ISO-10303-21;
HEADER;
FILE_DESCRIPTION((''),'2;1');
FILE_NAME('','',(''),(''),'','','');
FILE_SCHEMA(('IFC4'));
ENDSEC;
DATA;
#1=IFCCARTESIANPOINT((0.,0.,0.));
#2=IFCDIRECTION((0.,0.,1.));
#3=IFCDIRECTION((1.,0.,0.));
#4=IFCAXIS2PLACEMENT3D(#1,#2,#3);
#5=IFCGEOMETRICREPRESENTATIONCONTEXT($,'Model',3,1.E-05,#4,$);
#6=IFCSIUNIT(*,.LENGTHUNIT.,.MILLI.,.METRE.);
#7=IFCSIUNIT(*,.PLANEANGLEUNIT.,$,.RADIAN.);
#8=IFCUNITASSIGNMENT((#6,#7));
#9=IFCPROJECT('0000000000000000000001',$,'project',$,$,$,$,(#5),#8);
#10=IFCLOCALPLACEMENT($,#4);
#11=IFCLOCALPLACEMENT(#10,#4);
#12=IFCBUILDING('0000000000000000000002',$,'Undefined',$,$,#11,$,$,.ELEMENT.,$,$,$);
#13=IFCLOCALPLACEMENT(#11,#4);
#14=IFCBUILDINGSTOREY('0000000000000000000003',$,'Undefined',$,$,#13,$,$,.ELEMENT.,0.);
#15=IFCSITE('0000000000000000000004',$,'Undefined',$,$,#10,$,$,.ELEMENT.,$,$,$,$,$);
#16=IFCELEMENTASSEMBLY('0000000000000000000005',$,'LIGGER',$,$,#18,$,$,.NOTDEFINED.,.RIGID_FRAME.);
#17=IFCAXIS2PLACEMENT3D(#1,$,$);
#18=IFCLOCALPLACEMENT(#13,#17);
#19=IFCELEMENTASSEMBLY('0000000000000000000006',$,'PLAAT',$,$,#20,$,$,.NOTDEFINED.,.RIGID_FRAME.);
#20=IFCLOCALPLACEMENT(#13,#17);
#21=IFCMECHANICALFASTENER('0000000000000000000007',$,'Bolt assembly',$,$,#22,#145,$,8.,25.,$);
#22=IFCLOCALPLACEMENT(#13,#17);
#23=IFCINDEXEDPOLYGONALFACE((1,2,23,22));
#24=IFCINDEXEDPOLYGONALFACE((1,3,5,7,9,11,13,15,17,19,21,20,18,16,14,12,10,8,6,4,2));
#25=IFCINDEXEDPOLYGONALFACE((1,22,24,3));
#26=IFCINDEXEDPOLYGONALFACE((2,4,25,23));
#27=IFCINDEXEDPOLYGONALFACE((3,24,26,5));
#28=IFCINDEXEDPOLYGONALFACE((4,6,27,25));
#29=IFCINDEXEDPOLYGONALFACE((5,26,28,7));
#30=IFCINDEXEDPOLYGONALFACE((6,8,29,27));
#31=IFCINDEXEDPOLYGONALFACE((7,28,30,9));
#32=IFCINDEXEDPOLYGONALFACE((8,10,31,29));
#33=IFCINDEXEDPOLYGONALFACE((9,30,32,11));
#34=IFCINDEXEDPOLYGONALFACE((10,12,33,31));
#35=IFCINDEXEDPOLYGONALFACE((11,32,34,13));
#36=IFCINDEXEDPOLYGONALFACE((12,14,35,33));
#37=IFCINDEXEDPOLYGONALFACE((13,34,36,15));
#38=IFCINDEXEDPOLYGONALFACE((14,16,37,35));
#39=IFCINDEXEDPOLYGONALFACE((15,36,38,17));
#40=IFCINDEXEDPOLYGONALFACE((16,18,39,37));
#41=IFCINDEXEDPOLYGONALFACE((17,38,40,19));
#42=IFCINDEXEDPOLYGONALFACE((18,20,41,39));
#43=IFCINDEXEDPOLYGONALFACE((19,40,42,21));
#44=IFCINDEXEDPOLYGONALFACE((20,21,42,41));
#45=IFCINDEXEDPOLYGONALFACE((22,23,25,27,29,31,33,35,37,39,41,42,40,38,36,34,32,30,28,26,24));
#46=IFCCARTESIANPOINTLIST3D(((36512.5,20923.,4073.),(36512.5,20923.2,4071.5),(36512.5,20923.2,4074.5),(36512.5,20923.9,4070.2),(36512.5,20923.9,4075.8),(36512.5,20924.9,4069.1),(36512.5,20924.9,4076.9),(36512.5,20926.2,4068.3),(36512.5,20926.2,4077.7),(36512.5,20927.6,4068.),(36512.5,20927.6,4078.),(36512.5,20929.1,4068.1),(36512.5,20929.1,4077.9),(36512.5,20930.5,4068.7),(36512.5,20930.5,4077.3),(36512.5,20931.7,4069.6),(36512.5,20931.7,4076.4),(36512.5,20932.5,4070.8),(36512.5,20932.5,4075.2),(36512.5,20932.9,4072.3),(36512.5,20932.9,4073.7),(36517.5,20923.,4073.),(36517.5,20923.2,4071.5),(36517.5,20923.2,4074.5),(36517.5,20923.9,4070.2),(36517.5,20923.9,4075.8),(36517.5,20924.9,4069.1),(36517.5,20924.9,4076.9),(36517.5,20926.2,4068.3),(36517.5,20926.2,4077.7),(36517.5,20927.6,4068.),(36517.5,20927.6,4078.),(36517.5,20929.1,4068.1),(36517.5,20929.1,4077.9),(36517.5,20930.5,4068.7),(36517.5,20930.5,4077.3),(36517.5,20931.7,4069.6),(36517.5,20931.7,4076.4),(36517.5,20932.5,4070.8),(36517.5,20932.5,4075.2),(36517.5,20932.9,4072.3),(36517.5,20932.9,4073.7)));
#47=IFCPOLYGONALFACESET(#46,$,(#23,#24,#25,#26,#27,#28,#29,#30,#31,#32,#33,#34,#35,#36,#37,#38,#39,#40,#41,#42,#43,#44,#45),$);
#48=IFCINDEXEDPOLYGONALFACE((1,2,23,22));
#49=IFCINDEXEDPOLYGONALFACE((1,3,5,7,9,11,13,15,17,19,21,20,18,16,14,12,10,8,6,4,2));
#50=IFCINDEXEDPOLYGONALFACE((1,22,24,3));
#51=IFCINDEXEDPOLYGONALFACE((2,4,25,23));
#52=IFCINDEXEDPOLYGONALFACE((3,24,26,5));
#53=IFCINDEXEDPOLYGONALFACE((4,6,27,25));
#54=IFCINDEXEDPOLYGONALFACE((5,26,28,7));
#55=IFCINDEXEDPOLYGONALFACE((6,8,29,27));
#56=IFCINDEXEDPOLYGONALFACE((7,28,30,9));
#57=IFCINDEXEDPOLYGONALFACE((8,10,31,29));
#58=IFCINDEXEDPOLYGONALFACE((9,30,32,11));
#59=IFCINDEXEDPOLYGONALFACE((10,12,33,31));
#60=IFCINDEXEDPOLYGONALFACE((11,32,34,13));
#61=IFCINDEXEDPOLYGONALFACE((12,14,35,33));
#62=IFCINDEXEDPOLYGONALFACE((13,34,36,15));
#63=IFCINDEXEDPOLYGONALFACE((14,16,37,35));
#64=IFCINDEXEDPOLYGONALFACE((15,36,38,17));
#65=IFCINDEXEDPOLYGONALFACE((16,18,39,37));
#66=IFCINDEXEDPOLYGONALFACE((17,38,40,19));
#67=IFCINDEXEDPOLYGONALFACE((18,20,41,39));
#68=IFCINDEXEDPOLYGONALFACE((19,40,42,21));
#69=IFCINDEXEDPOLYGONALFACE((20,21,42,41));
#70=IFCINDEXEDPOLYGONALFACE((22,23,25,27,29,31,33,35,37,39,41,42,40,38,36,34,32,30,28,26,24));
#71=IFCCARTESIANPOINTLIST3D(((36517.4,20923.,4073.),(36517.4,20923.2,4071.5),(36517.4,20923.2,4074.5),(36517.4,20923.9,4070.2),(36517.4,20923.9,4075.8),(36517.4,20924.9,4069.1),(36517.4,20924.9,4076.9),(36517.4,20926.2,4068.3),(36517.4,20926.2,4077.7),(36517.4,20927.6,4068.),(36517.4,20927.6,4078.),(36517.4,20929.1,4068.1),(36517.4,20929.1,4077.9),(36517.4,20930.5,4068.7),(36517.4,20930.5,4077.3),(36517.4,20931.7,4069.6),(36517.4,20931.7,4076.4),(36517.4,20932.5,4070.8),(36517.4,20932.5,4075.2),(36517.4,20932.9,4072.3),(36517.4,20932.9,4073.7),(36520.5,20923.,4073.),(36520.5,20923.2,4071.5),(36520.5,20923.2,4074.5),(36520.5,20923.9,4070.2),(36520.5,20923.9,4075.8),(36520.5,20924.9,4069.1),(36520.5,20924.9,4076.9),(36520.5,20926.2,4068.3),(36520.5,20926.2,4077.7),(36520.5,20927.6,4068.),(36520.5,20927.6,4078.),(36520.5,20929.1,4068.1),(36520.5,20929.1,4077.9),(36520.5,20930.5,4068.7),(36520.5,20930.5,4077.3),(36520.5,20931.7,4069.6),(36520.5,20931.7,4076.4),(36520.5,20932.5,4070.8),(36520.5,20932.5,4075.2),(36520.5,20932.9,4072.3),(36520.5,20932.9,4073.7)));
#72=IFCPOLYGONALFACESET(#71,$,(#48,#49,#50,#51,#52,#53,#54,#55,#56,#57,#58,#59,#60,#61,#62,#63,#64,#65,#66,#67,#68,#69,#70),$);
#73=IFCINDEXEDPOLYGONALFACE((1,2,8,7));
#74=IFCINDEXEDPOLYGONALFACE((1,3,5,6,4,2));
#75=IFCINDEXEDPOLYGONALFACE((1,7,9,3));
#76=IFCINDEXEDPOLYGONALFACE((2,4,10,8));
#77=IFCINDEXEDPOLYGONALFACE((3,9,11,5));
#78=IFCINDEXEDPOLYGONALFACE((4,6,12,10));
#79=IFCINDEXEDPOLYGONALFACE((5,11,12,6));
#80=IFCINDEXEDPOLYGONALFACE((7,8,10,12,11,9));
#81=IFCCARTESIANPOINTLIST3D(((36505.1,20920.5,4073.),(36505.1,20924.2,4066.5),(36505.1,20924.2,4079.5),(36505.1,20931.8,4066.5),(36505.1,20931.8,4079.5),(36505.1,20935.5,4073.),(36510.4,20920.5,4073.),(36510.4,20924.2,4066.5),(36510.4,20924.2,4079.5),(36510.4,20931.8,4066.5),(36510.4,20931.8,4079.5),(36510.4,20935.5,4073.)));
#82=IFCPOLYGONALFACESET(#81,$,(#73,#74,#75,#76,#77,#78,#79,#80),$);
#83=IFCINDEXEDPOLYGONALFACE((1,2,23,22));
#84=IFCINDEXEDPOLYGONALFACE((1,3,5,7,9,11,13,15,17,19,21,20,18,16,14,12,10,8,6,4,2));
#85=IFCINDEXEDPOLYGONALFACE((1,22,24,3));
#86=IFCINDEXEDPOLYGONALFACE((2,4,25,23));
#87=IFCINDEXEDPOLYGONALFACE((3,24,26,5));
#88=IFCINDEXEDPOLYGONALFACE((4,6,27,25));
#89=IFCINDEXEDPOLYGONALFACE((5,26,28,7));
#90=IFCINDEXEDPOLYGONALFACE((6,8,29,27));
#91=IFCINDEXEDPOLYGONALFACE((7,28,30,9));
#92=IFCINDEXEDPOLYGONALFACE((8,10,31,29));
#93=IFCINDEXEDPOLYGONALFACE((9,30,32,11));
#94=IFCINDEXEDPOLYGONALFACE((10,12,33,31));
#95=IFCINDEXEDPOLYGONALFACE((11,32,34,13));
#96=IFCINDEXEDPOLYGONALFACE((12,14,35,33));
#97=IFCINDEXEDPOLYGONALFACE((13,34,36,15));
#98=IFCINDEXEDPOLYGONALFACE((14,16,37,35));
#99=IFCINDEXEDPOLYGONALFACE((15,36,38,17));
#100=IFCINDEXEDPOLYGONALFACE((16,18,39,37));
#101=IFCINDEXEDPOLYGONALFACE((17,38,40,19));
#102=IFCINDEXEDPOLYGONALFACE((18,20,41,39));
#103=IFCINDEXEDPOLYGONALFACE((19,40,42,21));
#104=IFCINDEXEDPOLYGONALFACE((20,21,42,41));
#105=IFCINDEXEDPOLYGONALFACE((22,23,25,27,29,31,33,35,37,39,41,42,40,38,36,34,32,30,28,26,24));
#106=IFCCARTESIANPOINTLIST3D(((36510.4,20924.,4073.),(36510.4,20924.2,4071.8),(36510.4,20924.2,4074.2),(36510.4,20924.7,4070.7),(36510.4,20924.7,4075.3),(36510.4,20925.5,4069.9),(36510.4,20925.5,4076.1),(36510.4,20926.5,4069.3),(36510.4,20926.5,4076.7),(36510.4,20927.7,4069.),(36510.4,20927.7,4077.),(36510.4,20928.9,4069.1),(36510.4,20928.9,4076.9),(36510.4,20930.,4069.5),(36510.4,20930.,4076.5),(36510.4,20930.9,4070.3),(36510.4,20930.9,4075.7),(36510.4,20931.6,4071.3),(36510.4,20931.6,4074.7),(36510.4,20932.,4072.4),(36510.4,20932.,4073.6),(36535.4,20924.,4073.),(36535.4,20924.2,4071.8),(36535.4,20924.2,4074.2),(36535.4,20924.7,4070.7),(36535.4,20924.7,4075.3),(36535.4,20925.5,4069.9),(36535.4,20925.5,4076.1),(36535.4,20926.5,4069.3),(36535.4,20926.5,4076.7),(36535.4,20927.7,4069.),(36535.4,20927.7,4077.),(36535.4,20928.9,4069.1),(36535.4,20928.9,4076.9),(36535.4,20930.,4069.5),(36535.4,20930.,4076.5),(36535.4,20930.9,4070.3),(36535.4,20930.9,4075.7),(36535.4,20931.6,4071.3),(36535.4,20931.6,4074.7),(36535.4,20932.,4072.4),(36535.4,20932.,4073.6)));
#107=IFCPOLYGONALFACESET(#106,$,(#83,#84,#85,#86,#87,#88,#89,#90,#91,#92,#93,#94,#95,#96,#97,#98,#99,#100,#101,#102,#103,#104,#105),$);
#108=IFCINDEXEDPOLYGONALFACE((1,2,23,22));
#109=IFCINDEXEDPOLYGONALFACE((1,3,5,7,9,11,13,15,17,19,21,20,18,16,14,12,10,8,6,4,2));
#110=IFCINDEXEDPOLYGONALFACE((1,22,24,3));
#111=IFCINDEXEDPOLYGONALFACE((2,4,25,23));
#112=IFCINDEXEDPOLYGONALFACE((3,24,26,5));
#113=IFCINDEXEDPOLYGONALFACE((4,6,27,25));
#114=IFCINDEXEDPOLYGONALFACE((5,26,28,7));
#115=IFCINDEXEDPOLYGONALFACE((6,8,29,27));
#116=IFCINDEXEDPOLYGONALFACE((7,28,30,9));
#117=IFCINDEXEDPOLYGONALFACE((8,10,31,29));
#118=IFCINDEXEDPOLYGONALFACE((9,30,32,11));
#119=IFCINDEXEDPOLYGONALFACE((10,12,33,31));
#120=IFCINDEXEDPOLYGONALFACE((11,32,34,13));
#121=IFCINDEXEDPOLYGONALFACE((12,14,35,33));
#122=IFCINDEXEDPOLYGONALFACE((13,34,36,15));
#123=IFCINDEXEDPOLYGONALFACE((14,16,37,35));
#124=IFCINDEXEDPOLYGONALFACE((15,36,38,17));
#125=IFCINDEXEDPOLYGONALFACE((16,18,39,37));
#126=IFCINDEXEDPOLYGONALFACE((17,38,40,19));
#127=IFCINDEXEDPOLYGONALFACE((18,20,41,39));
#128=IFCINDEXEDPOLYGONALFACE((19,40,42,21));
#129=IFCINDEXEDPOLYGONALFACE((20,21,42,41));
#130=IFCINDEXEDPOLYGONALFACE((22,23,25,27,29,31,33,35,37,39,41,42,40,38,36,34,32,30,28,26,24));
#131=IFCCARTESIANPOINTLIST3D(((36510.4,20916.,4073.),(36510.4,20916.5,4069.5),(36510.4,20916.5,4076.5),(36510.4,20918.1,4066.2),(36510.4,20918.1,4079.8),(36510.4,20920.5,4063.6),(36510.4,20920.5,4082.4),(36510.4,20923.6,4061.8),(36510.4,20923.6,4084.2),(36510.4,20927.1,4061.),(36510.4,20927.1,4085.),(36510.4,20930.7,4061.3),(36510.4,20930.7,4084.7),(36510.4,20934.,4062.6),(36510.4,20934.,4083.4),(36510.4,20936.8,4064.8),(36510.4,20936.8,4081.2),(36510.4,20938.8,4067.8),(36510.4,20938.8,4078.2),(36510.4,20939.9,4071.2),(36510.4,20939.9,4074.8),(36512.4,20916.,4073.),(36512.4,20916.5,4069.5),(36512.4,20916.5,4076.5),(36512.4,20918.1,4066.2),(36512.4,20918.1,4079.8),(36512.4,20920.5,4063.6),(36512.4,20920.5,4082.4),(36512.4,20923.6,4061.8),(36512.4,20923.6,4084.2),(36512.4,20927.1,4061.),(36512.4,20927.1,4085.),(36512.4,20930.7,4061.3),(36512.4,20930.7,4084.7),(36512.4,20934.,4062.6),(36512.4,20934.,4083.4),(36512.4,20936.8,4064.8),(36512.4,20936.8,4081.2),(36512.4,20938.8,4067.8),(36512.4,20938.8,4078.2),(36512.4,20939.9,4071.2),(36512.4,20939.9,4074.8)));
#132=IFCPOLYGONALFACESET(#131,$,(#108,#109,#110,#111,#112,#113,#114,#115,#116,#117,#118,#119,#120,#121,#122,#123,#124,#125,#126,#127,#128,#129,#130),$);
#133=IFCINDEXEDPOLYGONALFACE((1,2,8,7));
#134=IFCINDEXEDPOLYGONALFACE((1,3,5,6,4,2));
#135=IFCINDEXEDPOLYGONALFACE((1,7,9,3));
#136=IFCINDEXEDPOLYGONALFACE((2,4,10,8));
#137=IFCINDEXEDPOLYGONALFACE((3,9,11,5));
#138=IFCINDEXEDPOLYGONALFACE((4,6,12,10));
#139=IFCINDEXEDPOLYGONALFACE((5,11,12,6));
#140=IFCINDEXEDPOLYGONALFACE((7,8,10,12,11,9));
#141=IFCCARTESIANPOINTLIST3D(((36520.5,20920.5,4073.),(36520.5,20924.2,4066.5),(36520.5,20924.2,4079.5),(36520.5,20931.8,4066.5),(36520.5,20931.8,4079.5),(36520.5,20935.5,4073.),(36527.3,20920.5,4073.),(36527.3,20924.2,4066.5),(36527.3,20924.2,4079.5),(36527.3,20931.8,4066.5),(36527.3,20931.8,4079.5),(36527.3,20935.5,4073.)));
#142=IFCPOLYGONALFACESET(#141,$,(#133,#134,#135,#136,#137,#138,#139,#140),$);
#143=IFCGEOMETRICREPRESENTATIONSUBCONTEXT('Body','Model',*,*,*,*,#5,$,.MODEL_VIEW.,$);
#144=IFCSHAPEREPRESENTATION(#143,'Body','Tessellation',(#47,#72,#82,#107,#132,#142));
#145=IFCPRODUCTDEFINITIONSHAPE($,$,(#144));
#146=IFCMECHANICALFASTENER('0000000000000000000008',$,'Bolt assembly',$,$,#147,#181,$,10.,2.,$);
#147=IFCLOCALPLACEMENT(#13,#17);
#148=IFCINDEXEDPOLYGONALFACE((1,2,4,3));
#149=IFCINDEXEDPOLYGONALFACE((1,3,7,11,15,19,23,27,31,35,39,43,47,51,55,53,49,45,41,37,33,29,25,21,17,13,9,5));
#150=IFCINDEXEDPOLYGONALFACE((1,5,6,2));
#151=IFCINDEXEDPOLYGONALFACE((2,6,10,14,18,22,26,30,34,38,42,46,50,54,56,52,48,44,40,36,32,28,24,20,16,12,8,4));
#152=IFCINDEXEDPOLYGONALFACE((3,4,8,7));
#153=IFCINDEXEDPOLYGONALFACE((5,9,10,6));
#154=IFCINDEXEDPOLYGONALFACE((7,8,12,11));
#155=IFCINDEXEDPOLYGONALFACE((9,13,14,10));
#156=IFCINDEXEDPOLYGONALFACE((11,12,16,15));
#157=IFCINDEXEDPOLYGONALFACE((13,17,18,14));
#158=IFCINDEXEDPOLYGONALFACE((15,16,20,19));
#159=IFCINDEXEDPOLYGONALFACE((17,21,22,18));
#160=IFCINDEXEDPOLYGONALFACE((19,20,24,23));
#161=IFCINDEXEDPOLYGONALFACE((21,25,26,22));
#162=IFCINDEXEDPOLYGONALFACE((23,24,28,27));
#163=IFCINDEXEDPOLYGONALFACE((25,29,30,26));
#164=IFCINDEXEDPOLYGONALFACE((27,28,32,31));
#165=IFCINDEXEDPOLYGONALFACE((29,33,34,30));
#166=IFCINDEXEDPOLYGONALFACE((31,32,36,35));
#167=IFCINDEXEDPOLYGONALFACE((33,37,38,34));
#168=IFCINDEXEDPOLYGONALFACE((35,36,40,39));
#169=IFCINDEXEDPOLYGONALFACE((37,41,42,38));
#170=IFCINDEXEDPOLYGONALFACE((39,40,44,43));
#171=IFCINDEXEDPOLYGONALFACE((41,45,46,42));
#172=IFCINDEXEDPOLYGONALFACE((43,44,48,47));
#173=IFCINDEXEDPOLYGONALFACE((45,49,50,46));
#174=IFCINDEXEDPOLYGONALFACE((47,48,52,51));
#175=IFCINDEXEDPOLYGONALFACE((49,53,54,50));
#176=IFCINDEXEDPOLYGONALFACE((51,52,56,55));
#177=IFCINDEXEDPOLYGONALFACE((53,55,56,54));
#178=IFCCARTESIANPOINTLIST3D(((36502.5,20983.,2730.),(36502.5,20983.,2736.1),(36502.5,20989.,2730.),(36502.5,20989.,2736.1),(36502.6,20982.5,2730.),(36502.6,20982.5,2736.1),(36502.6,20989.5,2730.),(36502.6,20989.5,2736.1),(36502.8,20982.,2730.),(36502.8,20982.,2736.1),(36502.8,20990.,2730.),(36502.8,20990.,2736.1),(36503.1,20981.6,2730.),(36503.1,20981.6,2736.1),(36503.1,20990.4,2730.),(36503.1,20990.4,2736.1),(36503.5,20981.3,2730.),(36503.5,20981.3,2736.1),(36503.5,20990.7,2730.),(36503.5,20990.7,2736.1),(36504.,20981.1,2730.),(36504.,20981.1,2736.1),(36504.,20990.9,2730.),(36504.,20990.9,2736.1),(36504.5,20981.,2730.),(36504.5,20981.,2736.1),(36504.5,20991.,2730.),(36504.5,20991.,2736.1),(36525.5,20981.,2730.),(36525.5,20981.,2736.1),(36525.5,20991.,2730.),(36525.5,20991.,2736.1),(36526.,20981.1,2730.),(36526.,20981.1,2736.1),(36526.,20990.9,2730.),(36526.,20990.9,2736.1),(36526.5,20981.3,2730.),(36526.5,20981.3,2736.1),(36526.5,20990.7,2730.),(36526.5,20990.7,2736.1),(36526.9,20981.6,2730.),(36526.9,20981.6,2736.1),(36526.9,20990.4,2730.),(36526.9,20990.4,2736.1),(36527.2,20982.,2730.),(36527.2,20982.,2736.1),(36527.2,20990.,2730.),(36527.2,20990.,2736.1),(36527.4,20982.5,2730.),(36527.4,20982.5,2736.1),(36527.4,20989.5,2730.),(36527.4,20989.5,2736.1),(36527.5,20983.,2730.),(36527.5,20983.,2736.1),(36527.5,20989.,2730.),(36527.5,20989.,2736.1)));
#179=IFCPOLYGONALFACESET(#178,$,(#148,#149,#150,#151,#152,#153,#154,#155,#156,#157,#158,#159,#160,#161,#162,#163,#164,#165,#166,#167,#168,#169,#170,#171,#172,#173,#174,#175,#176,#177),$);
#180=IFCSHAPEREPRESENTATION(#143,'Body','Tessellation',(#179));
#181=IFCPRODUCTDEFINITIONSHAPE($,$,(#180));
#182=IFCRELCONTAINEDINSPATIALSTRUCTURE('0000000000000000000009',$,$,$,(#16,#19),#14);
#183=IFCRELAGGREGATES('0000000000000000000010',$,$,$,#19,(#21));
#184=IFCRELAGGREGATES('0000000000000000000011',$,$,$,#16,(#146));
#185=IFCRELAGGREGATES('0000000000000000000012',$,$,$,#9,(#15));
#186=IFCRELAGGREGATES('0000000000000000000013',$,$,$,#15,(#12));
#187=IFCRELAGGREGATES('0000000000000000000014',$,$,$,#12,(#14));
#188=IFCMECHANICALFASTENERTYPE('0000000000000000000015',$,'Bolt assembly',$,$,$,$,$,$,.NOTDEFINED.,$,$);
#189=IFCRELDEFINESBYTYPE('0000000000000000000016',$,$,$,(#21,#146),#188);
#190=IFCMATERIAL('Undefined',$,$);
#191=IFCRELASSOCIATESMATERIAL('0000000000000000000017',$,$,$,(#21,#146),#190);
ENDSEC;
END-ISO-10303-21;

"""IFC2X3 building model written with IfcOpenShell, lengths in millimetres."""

from ifc_helpers import new_model, si_unit, frame, frame_2d, origin_with_axes, origin_2d_with_axis, place, context, subcontext, project, spatial, polyline, circle_curve, parameter, trimmed, segment, composite_curve, circle, outline, extrude, source, transform, mapped, material, type_object, element, aggregate, save


model = new_model("IFC2X3")

# Units and contexts
model_context = context("Model", 3, precision=1e-05, world=origin_with_axes())
body_context = subcontext(model_context, "Body", "Model", "MODEL_VIEW")
ifc_project = project(units=[si_unit("LENGTHUNIT", "METRE", prefix="MILLI"), si_unit("PLANEANGLEUNIT", "RADIAN")], contexts=[model_context])

# Site, building, storey
site_placement = place(None, origin_with_axes())
site = spatial("IfcSite", under=ifc_project, at=site_placement, Name="Undefined", CompositionType="ELEMENT")
building_placement = place(site_placement, origin_with_axes())
building = spatial("IfcBuilding", under=site, at=building_placement, Name="Undefined", CompositionType="ELEMENT")
storey_placement = place(building_placement, origin_with_axes())
storey = spatial("IfcBuildingStorey", under=building, at=storey_placement, Name="Undefined", CompositionType="ELEMENT", Elevation=0.0)

# Element assembly
assembly_1_placement = place(storey_placement, origin_with_axes())
assembly_1 = element("IfcElementAssembly", 1, at=assembly_1_placement, inside=storey, Name="LIGGER", AssemblyPlace="NOTDEFINED", PredefinedType="RIGID_FRAME")

# Element assembly
ifc_material_1 = material(Name="Undefined")
mechanical_fastener_type = type_object("IfcMechanicalFastenerType", Name="Bolt assembly")
assembly_2_placement = place(storey_placement, origin_with_axes())
assembly_2 = element("IfcElementAssembly", 2, at=assembly_2_placement, inside=storey, Name="PLAAT", AssemblyPlace="NOTDEFINED", PredefinedType="RIGID_FRAME")
shared_shape_1 = source(origin_with_axes(), body_context, "Body", "SweptSolid", [
    extrude(circle(Radius=5.0, at=origin_2d_with_axis()), frame((0.0, 7.5, 0.0), z_axis=(0.0, 1.0, 0.0), x_axis=(1.0, 0.0, 0.0)), (0.0, 0.0, 1.0), 5.0),
    extrude(circle(Radius=5.0, at=origin_2d_with_axis()), frame((0.0, 12.4, 0.0), z_axis=(0.0, 1.0, 0.0), x_axis=(1.0, 0.0, 0.0)), (0.0, 0.0, 1.0), 3.1),
    extrude(outline(polyline([(7.5, 0.0), (3.8, 6.5), (-3.8, 6.5), (-7.5, 0.0), (-3.8, -6.5), (3.8, -6.5), (7.5, 0.0)])), frame((0.0, 0.1, 0.0), z_axis=(0.0, 1.0, 0.0), x_axis=(1.0, 0.0, 0.0)), (0.0, 0.0, 1.0), 5.3),
    extrude(circle(Radius=4.0, at=origin_2d_with_axis()), frame((0.0, 5.4, 0.0), z_axis=(0.0, 1.0, 0.0), x_axis=(1.0, 0.0, 0.0)), (0.0, 0.0, 1.0), 25.0),
    extrude(circle(Radius=12.0, at=origin_2d_with_axis()), frame((0.0, 5.4, 0.0), z_axis=(0.0, 1.0, 0.0), x_axis=(1.0, 0.0, 0.0)), (0.0, 0.0, 1.0), 2.0),
    extrude(outline(polyline([(7.5, 0.0), (3.8, 6.5), (-3.8, 6.5), (-7.5, 0.0), (-3.8, -6.5), (3.8, -6.5), (7.5, 0.0)])), frame((0.0, 15.5, 0.0), z_axis=(0.0, 1.0, 0.0), x_axis=(1.0, 0.0, 0.0)), (0.0, 0.0, 1.0), 6.8),
])

# Mechanical fasteners
mechanical_fastener_1_placement = place(assembly_2_placement, frame((36505.0, 20928.0, 4073.0), z_axis=(0.0, 0.000002, 1.0), x_axis=(0.0, -1.0, 0.000002)))
mechanical_fastener_1 = element("IfcMechanicalFastener", 3, at=mechanical_fastener_1_placement, type_object=mechanical_fastener_type, material=ifc_material_1, Name="Bolt assembly", NominalDiameter=8.0, NominalLength=25.0, context=body_context, shape_type="MappedRepresentation", body=[
    mapped(shared_shape_1, transform((0.0, 0.0, 0.0))),
])
aggregate(assembly_2, [mechanical_fastener_1])
shared_shape_2 = source(origin_with_axes(), body_context, "Body", "SweptSolid", [
    extrude(outline(composite_curve([segment(polyline([(-3.0, 12.5), (3.0, 12.5)]), True, "CONTINUOUS"), segment(trimmed(circle_curve(frame_2d((3.0, 10.5), x_axis=(0.0, 1.0)), 2.0), [parameter(0.0)], [parameter(4.712389)], False, "PARAMETER"), True, "CONTINUOUS"), segment(polyline([(5.0, 10.5), (5.0, -10.5)]), True, "CONTINUOUS"), segment(trimmed(circle_curve(frame_2d((3.0, -10.5), x_axis=(1.0, 0.0)), 2.0), [parameter(0.0)], [parameter(4.712389)], False, "PARAMETER"), True, "CONTINUOUS"), segment(polyline([(3.0, -12.5), (-3.0, -12.5)]), True, "CONTINUOUS"), segment(trimmed(circle_curve(frame_2d((-3.0, -10.5), x_axis=(0.0, -1.0)), 2.0), [parameter(0.0)], [parameter(4.712389)], False, "PARAMETER"), True, "CONTINUOUS"), segment(polyline([(-5.0, -10.5), (-5.0, 10.5)]), True, "CONTINUOUS"), segment(trimmed(circle_curve(frame_2d((-3.0, 10.5), x_axis=(-1.0, 0.0)), 2.0), [parameter(0.0)], [parameter(4.712389)], False, "PARAMETER"), True, "DISCONTINUOUS")], self_intersect=False)), frame((0.0, 0.0, 0.0), z_axis=(0.0, 1.0, 0.0), x_axis=(1.0, 0.0, 0.0)), (0.0, 0.0, 1.0), 6.1),
])
mechanical_fastener_2_placement = place(assembly_1_placement, frame((36515.0, 20986.0, 2730.0), z_axis=(-1.0, 0.0, 0.0), x_axis=(0.0, -1.0, 0.0)))
mechanical_fastener_2 = element("IfcMechanicalFastener", 4, at=mechanical_fastener_2_placement, type_object=mechanical_fastener_type, material=ifc_material_1, Name="Bolt assembly", NominalDiameter=10.0, NominalLength=2.0, context=body_context, shape_type="MappedRepresentation", body=[
    mapped(shared_shape_2, transform((0.0, 0.0, 0.0))),
])
aggregate(assembly_1, [mechanical_fastener_2])

save(model, "model.ifc")
